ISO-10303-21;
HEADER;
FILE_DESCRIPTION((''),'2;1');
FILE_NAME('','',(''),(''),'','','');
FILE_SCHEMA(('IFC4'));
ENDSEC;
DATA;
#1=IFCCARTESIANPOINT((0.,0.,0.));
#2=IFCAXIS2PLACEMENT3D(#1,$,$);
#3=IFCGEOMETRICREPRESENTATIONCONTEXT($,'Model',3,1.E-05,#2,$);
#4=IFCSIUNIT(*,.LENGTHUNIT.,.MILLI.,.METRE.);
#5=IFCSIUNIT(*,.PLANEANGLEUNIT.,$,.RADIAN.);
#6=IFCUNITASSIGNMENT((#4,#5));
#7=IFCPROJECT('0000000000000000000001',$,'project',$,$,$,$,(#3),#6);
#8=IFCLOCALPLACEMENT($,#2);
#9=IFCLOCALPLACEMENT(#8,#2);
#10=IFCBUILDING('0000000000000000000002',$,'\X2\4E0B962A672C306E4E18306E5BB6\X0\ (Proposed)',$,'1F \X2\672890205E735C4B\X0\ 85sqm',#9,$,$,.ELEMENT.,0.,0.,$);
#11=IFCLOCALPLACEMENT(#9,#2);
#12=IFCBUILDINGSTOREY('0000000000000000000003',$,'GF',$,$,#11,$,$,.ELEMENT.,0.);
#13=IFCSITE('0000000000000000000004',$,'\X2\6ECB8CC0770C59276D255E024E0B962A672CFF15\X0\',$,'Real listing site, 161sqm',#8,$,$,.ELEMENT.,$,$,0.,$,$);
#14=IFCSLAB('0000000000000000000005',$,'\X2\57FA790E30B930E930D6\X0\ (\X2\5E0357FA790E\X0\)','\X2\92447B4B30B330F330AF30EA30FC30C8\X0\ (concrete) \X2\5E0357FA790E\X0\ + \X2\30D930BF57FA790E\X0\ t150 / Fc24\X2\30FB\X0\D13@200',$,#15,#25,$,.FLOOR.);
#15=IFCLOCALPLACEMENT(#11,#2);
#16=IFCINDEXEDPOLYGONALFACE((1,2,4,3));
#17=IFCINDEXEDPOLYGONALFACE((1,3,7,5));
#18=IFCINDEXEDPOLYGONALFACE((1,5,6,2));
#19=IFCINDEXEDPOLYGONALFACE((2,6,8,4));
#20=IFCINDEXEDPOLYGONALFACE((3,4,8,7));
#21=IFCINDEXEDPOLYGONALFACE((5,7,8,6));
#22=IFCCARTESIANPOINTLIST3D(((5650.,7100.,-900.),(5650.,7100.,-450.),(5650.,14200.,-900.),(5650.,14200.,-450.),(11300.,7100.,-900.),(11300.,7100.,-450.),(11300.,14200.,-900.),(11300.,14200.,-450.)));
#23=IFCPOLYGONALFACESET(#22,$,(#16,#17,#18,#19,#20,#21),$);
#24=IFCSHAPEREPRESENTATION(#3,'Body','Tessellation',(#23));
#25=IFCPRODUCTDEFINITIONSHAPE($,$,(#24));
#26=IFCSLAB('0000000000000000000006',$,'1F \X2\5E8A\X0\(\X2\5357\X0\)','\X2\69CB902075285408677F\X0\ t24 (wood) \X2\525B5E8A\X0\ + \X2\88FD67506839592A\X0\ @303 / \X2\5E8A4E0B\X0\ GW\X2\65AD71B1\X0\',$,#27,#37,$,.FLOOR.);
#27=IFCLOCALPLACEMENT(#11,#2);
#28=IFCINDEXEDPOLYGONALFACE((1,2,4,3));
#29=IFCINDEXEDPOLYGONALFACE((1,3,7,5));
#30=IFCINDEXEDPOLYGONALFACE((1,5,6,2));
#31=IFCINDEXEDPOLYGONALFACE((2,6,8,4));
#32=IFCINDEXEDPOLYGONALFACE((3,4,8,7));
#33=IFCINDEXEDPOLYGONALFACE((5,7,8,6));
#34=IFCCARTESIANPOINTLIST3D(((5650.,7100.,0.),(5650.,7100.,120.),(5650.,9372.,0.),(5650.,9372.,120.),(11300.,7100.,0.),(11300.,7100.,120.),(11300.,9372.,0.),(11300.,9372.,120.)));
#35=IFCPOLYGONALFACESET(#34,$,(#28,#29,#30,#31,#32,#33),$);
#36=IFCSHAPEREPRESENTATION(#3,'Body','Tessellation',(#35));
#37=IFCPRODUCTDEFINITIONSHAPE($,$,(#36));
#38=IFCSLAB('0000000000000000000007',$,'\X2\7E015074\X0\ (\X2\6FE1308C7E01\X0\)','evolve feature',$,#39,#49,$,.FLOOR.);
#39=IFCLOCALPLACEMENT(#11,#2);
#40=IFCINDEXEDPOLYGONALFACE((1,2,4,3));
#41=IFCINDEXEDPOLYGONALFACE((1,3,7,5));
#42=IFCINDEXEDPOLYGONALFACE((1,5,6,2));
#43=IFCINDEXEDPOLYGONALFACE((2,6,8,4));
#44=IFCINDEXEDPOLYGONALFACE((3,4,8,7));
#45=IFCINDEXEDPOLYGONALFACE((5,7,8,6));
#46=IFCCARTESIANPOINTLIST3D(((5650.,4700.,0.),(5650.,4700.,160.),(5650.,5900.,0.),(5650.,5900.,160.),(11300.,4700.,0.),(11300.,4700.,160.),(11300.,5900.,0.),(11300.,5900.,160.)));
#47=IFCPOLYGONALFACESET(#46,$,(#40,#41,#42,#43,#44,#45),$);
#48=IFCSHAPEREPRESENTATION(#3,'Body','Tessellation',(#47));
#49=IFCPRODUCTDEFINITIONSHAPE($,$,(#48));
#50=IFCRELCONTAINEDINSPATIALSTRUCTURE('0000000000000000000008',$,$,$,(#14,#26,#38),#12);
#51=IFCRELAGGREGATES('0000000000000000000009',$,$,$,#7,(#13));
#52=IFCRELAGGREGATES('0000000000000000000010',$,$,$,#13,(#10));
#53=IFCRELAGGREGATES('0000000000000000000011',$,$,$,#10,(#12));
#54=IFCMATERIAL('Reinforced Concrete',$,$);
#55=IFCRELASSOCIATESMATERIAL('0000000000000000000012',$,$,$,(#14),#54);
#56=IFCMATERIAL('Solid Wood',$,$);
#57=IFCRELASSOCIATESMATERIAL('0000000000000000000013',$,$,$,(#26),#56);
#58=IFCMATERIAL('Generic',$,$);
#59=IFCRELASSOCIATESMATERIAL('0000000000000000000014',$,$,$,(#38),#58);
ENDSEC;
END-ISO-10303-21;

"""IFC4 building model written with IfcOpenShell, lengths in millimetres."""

from ifc_helpers import new_model, si_unit, frame, frame_2d, origin, place, context, project, spatial, rectangle, extrude, material, element, save


model = new_model("IFC4")

# Units and contexts
model_context = context("Model", 3, precision=1e-05, world=origin())
ifc_project = project(units=[si_unit("LENGTHUNIT", "METRE", prefix="MILLI"), si_unit("PLANEANGLEUNIT", "RADIAN")], contexts=[model_context])

# Site, building, storey
site_placement = place(None, origin())
site = spatial("IfcSite", under=ifc_project, at=site_placement, Name="滋賀県大津市下阪本５", ObjectType="Real listing site, 161sqm", CompositionType="ELEMENT", RefElevation=0.0)
building_placement = place(site_placement, origin())
building = spatial("IfcBuilding", under=site, at=building_placement, Name="下阪本の丘の家 (Proposed)", ObjectType="1F 木造平屋 85sqm", CompositionType="ELEMENT", ElevationOfRefHeight=0.0, ElevationOfTerrain=0.0)
storey_placement = place(building_placement, origin())
storey = spatial("IfcBuildingStorey", under=building, at=storey_placement, Name="GF", CompositionType="ELEMENT", Elevation=0.0)

# Slabs
ifc_material_1 = material(Name="Reinforced Concrete")
slab_1_placement = place(storey_placement, frame((2825.0, 3550.0, -450.0)))
element("IfcSlab", 1, at=slab_1_placement, inside=storey, material=ifc_material_1, Name="基礎スラブ (布基礎)", Description="鉄筋コンクリート (concrete) 布基礎 + ベタ基礎 t150 / Fc24・D13@200", PredefinedType="FLOOR", context=model_context, shape_type="SweptSolid", body=[
    extrude(rectangle(XDim=5650.0, YDim=7100.0, at=frame_2d((2825.0, 3550.0))), frame((2825.0, 3550.0, -450.0)), (0.0, 0.0, 1.0), 450.0),
])
ifc_material_2 = material(Name="Solid Wood")
slab_2_placement = place(storey_placement, frame((2825.0, 3550.0, 0.0)))
element("IfcSlab", 2, at=slab_2_placement, inside=storey, material=ifc_material_2, Name="1F 床(南)", Description="構造用合板 t24 (wood) 剛床 + 製材根太 @303 / 床下 GW断熱", PredefinedType="FLOOR", context=model_context, shape_type="SweptSolid", body=[
    extrude(rectangle(XDim=5650.0, YDim=2272.0, at=frame_2d((2825.0, 1136.0))), frame((2825.0, 3550.0, 0.0)), (0.0, 0.0, 1.0), 120.0),
])
ifc_material_3 = material(Name="Generic")
slab_3_placement = place(storey_placement, frame((2825.0, 2350.0, 0.0)))
element("IfcSlab", 3, at=slab_3_placement, inside=storey, material=ifc_material_3, Name="縁側 (濡れ縁)", Description="evolve feature", PredefinedType="FLOOR", context=model_context, shape_type="SweptSolid", body=[
    extrude(rectangle(XDim=5650.0, YDim=1200.0, at=frame_2d((2825.0, 600.0))), frame((2825.0, 2350.0, 0.0)), (0.0, 0.0, 1.0), 160.0),
])

save(model, "model.ifc")
